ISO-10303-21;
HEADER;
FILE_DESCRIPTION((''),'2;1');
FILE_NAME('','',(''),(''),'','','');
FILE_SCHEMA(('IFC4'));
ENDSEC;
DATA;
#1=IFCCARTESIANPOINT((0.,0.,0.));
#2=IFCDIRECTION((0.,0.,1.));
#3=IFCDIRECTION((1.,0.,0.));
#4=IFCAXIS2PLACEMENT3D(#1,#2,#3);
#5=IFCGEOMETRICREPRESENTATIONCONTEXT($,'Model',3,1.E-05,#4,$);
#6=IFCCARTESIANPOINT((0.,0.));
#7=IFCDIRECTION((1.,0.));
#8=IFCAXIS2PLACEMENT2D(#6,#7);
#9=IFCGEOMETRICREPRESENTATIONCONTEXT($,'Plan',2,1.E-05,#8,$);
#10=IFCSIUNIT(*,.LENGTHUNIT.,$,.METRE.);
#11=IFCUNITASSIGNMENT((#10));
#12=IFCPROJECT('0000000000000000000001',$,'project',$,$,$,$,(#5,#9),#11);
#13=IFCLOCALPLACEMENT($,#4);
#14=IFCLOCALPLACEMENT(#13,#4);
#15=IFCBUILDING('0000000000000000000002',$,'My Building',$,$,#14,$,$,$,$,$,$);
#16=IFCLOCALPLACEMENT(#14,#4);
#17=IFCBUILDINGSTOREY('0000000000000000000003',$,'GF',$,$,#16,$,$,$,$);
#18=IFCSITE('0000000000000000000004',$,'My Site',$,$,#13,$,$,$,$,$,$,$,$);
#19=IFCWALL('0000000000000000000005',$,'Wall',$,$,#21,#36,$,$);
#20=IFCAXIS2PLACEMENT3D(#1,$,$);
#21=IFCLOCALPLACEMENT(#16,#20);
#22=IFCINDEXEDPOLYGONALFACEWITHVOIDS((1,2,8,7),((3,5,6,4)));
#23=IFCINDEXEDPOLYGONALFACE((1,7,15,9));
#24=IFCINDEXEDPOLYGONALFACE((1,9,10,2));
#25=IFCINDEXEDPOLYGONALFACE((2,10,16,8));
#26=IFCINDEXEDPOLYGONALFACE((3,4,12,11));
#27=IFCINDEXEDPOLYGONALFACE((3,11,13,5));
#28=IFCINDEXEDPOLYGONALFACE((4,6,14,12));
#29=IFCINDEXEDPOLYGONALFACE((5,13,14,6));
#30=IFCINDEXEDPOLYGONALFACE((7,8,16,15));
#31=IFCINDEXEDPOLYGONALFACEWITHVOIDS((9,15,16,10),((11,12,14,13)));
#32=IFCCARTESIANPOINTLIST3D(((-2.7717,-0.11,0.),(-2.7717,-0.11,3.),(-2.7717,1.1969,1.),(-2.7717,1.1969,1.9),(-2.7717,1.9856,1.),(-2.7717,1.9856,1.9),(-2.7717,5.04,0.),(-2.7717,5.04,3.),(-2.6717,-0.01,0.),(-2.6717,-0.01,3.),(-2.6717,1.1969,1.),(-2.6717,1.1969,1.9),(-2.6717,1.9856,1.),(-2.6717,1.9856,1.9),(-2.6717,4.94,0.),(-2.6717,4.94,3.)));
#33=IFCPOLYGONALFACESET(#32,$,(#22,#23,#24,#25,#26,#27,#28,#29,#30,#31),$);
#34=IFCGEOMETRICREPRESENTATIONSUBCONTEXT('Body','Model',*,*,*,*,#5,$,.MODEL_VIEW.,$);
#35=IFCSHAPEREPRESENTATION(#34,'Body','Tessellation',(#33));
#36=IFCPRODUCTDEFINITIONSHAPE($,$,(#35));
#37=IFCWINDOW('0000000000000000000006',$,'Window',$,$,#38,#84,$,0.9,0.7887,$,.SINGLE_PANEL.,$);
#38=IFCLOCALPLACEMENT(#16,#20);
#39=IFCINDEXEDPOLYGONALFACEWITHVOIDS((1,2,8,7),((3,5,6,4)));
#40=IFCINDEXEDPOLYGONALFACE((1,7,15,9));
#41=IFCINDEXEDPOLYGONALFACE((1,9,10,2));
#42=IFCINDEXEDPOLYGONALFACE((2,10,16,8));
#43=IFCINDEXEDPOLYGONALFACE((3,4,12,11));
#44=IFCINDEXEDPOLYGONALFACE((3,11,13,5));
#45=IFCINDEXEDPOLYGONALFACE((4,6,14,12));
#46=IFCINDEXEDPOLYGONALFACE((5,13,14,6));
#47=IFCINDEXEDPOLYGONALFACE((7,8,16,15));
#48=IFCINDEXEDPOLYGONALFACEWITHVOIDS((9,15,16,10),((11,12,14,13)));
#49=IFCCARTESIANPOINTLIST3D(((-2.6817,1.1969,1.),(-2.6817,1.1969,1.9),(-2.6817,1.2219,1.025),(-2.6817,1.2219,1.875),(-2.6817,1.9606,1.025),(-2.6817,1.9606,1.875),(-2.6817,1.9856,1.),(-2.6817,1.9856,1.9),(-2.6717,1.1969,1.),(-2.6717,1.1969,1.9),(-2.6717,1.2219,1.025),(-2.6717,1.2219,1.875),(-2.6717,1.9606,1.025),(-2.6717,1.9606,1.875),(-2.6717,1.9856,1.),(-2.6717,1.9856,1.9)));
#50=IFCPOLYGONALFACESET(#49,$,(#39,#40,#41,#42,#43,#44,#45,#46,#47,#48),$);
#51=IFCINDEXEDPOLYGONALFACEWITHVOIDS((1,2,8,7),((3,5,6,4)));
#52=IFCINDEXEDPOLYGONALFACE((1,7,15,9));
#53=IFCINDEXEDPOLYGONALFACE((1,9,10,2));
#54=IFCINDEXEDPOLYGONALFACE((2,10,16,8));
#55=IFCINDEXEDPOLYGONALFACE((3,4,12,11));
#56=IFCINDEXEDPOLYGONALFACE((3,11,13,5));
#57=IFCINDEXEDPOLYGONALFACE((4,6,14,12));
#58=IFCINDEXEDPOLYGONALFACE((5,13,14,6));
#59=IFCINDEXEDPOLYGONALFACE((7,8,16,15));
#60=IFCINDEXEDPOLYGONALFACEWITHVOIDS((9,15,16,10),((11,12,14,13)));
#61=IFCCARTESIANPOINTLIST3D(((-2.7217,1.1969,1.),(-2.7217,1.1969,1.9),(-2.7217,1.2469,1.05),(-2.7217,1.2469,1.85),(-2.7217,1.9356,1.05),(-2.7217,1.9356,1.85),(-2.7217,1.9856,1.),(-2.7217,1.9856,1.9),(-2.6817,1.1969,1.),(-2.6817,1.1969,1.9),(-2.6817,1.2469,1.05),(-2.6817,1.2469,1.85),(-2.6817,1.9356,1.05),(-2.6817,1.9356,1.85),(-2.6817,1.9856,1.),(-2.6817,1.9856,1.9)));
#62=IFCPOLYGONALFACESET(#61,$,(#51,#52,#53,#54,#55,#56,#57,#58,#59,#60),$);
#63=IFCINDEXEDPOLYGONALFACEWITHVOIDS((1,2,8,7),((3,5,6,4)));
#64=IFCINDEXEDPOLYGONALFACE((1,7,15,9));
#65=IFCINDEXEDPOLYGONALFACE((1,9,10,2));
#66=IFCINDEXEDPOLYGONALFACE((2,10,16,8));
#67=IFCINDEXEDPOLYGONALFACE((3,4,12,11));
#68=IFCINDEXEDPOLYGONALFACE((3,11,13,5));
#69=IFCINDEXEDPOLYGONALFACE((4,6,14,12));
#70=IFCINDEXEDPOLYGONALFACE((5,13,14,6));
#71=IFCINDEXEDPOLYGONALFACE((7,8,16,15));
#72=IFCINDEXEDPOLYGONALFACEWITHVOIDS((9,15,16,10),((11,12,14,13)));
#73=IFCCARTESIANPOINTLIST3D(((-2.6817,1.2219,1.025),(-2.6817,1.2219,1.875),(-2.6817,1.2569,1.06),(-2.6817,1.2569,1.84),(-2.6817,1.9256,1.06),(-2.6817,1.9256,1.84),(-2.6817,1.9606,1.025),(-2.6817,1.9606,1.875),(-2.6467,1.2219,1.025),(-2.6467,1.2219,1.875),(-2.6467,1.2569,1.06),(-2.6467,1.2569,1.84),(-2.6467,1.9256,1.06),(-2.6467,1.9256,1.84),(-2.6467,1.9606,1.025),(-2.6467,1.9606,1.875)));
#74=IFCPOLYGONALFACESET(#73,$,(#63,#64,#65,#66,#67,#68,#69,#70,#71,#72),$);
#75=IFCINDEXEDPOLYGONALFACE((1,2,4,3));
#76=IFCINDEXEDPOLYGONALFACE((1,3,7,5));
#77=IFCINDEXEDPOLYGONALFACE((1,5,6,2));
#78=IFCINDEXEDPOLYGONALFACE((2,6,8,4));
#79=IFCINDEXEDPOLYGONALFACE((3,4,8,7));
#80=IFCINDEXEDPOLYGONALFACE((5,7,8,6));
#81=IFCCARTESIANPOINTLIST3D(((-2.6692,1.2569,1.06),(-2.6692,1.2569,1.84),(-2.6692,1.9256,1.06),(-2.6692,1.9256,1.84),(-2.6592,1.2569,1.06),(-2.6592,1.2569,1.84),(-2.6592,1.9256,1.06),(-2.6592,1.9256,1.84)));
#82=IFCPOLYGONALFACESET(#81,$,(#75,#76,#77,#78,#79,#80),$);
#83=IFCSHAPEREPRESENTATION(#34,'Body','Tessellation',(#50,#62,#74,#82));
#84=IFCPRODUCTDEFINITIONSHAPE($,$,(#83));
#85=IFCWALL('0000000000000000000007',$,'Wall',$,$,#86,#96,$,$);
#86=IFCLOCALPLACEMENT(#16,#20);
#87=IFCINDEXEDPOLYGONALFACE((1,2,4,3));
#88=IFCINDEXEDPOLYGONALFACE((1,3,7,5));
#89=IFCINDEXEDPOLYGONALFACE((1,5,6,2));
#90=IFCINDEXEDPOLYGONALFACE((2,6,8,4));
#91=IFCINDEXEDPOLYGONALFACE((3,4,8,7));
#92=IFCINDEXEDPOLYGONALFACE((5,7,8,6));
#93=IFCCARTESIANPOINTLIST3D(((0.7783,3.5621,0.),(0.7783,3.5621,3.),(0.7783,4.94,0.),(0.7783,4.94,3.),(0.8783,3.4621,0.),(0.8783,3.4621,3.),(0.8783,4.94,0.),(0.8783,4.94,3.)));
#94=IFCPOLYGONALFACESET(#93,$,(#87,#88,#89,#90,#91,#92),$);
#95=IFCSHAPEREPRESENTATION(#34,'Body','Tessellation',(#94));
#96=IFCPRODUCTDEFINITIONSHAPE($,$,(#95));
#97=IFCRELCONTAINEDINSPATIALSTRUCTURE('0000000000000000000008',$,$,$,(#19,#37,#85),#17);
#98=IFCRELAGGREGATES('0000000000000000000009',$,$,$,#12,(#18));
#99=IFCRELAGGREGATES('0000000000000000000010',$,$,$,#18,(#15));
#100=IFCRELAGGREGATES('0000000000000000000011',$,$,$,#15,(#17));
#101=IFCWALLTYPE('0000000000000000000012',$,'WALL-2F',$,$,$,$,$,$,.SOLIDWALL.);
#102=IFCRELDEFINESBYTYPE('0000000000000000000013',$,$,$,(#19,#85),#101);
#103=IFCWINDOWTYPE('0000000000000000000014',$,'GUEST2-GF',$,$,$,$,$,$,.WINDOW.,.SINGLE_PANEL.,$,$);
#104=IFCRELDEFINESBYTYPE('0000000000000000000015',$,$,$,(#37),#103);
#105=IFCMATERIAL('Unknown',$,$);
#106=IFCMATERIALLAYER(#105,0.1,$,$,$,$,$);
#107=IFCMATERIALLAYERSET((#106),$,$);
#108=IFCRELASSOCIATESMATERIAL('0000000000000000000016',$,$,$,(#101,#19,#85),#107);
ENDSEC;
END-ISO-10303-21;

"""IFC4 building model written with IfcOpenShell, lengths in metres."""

from ifc_helpers import new_model, entity, si_unit, frame, origin_with_axes, origin_2d_with_axis, place, context, subcontext, project, spatial, line, indexed_curve, outline, extrude, shape, source, transform, mapped, material, layer, layer_set, layer_usage, type_object, type_shapes, element, fill, save


model = new_model("IFC4")

# Units and contexts
model_context = context("Model", 3, precision=1e-05, world=origin_with_axes())
plan_context = context("Plan", 2, precision=1e-05, world=origin_2d_with_axis())
body_context_1 = subcontext(model_context, "Body", "Model", "MODEL_VIEW")
body_context_2 = subcontext(plan_context, "Body", "Plan", "PLAN_VIEW")
ifc_project = project(units=[si_unit("LENGTHUNIT", "METRE")], contexts=[model_context, plan_context])

# Site, building, storey
site_placement = place(None, origin_with_axes())
site = spatial("IfcSite", under=ifc_project, at=site_placement, Name="My Site")
building_placement = place(site_placement, origin_with_axes())
building = spatial("IfcBuilding", under=site, at=building_placement, Name="My Building")
storey_placement = place(building_placement, origin_with_axes())
storey = spatial("IfcBuildingStorey", under=building, at=storey_placement, Name="GF")

# Shared definitions
ifc_material = material(Name="Unknown")
ifc_layer = layer(ifc_material, 0.1)
ifc_layer_set = layer_set([ifc_layer])
wall_type = type_object("IfcWallType", Name="WALL-2F", PredefinedType="SOLIDWALL", material=ifc_layer_set)

# Wall, opening, window
ifc_layer_usage_1 = layer_usage(ifc_layer_set, "AXIS2", "POSITIVE", 0.0)
wall_1_placement = place(storey_placement, frame((-2.7717, 5.04, 0.0), z_axis=(0.0, 0.0, 1.0), x_axis=(0.0, -1.0, 0.0)))
wall_1 = element("IfcWall", 1, at=wall_1_placement, inside=storey, type_object=wall_type, material=ifc_layer_usage_1, Name="Wall", context=body_context_1, shape_type="SweptSolid", body=[
    extrude(outline(indexed_curve([(0.0, 0.0), (0.1, 0.1), (5.05, 0.1), (5.15, 0.0)], segments=[line(1, 2, 3, 4, 1)])), origin_with_axes(), (0.0, 0.0, 1.0), 3.0),
])
shared_shape_1 = source(origin_with_axes(), body_context_1, "Body", "SweptSolid", [
    extrude(outline(indexed_curve([(0.0, 0.0), (0.7887, 0.0), (0.7887, 0.9), (0.0, 0.9)], segments=[line(1, 2, 3, 4, 1)])), frame((0.0, -0.6, 0.0), z_axis=(0.0, -1.0, 0.0), x_axis=(1.0, 0.0, 0.0)), (0.0, 0.0, -1.0), 1.2),
])
opening_1_placement = place(wall_1_placement, frame((3.0544, 0.0, 1.0), z_axis=(0.0, 0.0, 1.0), x_axis=(1.0, 0.0, 0.0)))
opening_1 = element("IfcOpeningElement", 2, at=opening_1_placement, cuts=wall_1, PredefinedType="OPENING", context=body_context_1, shape_type="MappedRepresentation", body=[
    mapped(shared_shape_1, transform((0.0, 0.0, 0.0), x_axis=(1.0, 0.0, 0.0), y_axis=(0.0, 1.0, 0.0), z_axis=(0.0, 0.0, 1.0), scale=1.0)),
])
window_type_1 = type_object("IfcWindowType", Name="GUEST2-GF", PartitioningType="SINGLE_PANEL", PredefinedType="WINDOW")
shared_shape_2 = source(origin_with_axes(), body_context_1, "Body", "SweptSolid", [
    extrude(outline(indexed_curve([(0.0, 0.0), (0.7887, 0.0), (0.7887, 0.9), (0.0, 0.9)], segments=[line(1, 2, 3, 4, 1)]), holes=[indexed_curve([(0.025, 0.025), (0.7637, 0.025), (0.7637, 0.875), (0.025, 0.875)], segments=[line(1, 2, 3, 4, 1)])]), frame((0.0, 0.09, 0.0), z_axis=(0.0, -1.0, 0.0), x_axis=(1.0, 0.0, 0.0)), (0.0, 0.0, -1.0), 0.01),
    extrude(outline(indexed_curve([(0.0, 0.0), (0.7887, 0.0), (0.7887, 0.9), (0.0, 0.9)], segments=[line(1, 2, 3, 4, 1)]), holes=[indexed_curve([(0.05, 0.05), (0.7387, 0.05), (0.7387, 0.85), (0.05, 0.85)], segments=[line(1, 2, 3, 4, 1)])]), frame((0.0, 0.05, 0.0), z_axis=(0.0, -1.0, 0.0), x_axis=(1.0, 0.0, 0.0)), (0.0, 0.0, -1.0), 0.04),
    extrude(outline(indexed_curve([(0.0, 0.0), (0.7387, 0.0), (0.7387, 0.85), (0.0, 0.85)], segments=[line(1, 2, 3, 4, 1)]), holes=[indexed_curve([(0.035, 0.035), (0.7037, 0.035), (0.7037, 0.815), (0.035, 0.815)], segments=[line(1, 2, 3, 4, 1)])]), frame((0.025, 0.09, 0.025), z_axis=(0.0, -1.0, 0.0), x_axis=(1.0, 0.0, 0.0)), (0.0, 0.0, -1.0), 0.035),
    extrude(outline(indexed_curve([(0.035, 0.035), (0.7037, 0.035), (0.7037, 0.815), (0.035, 0.815)], segments=[line(1, 2, 3, 4, 1)])), frame((0.025, 0.1025, 0.025), z_axis=(0.0, -1.0, 0.0), x_axis=(1.0, 0.0, 0.0)), (0.0, 0.0, -1.0), 0.01),
])
shared_shape_3 = source(origin_with_axes(), body_context_2, "Body", "Curve2D", [
    entity("IfcIndexedPolyCurve", entity("IfcCartesianPointList2D", [[0.05, 0.05], [0.7387, 0.05]])),
    entity("IfcIndexedPolyCurve", entity("IfcCartesianPointList2D", [[0.0, 0.1], [0.025, 0.1], [0.025, 0.09], [0.05, 0.09], [0.05, 0.05], [0.0, 0.05]]), [entity("IfcLineIndex", [1, 2, 3, 4, 5, 6, 1])]),
    entity("IfcIndexedPolyCurve", entity("IfcCartesianPointList2D", [[0.7887, 0.1], [0.7637, 0.1], [0.7637, 0.09], [0.7387, 0.09], [0.7387, 0.05], [0.7887, 0.05]]), [entity("IfcLineIndex", [1, 2, 3, 4, 5, 6, 1])]),
    entity("IfcIndexedPolyCurve", entity("IfcCartesianPointList2D", [[0.025, 0.09], [0.06, 0.09], [0.06, 0.125], [0.025, 0.125]]), [entity("IfcLineIndex", [1, 2, 3, 4, 1])]),
    entity("IfcIndexedPolyCurve", entity("IfcCartesianPointList2D", [[0.7637, 0.09], [0.7287, 0.09], [0.7287, 0.125], [0.7637, 0.125]]), [entity("IfcLineIndex", [1, 2, 3, 4, 1])]),
    entity("IfcIndexedPolyCurve", entity("IfcCartesianPointList2D", [[0.06, 0.09], [0.7287, 0.09]])),
    entity("IfcIndexedPolyCurve", entity("IfcCartesianPointList2D", [[0.06, 0.125], [0.7287, 0.125]])),
    entity("IfcIndexedPolyCurve", entity("IfcCartesianPointList2D", [[0.06, 0.1075], [0.7287, 0.1075]])),
])
type_shapes(window_type_1, [shared_shape_2, shared_shape_3])
window_1_placement = place(opening_1_placement, frame((0.0, 0.0, 0.0), z_axis=(0.0, 0.0, 1.0), x_axis=(1.0, 0.0, 0.0)))
window_1 = element("IfcWindow", 3, at=window_1_placement, inside=storey, type_object=window_type_1, Name="Window", OverallHeight=0.9, OverallWidth=0.7887, PartitioningType="SINGLE_PANEL", shapes=[
    shape(body_context_1, "Body", "MappedRepresentation", [mapped(shared_shape_2, transform((0.0, 0.0, 0.0), x_axis=(1.0, 0.0, 0.0), y_axis=(0.0, 1.0, 0.0), z_axis=(0.0, 0.0, 1.0), scale=1.0))]),
    shape(body_context_2, "Body", "MappedRepresentation", [mapped(shared_shape_3, transform((0.0, 0.0, 0.0), x_axis=(1.0, 0.0, 0.0), y_axis=(0.0, 1.0, 0.0), z_axis=(0.0, 0.0, 1.0), scale=1.0))]),
])
fill(opening_1, window_1)

# Wall
ifc_layer_usage_2 = layer_usage(ifc_layer_set, "AXIS2", "POSITIVE", 0.0)
wall_2_placement = place(storey_placement, frame((0.7783, 4.94, 0.0), z_axis=(0.0, 0.0, 1.0), x_axis=(0.0, -1.0, 0.0)))
element("IfcWall", 4, at=wall_2_placement, inside=storey, type_object=wall_type, material=ifc_layer_usage_2, Name="Wall", context=body_context_1, shape_type="SweptSolid", body=[
    extrude(outline(indexed_curve([(0.0, 0.0), (0.0, 0.1), (1.4779, 0.1), (1.3779, 0.0)], segments=[line(1, 2, 3, 4, 1)])), origin_with_axes(), (0.0, 0.0, 1.0), 3.0),
])

save(model, "model.ifc")
